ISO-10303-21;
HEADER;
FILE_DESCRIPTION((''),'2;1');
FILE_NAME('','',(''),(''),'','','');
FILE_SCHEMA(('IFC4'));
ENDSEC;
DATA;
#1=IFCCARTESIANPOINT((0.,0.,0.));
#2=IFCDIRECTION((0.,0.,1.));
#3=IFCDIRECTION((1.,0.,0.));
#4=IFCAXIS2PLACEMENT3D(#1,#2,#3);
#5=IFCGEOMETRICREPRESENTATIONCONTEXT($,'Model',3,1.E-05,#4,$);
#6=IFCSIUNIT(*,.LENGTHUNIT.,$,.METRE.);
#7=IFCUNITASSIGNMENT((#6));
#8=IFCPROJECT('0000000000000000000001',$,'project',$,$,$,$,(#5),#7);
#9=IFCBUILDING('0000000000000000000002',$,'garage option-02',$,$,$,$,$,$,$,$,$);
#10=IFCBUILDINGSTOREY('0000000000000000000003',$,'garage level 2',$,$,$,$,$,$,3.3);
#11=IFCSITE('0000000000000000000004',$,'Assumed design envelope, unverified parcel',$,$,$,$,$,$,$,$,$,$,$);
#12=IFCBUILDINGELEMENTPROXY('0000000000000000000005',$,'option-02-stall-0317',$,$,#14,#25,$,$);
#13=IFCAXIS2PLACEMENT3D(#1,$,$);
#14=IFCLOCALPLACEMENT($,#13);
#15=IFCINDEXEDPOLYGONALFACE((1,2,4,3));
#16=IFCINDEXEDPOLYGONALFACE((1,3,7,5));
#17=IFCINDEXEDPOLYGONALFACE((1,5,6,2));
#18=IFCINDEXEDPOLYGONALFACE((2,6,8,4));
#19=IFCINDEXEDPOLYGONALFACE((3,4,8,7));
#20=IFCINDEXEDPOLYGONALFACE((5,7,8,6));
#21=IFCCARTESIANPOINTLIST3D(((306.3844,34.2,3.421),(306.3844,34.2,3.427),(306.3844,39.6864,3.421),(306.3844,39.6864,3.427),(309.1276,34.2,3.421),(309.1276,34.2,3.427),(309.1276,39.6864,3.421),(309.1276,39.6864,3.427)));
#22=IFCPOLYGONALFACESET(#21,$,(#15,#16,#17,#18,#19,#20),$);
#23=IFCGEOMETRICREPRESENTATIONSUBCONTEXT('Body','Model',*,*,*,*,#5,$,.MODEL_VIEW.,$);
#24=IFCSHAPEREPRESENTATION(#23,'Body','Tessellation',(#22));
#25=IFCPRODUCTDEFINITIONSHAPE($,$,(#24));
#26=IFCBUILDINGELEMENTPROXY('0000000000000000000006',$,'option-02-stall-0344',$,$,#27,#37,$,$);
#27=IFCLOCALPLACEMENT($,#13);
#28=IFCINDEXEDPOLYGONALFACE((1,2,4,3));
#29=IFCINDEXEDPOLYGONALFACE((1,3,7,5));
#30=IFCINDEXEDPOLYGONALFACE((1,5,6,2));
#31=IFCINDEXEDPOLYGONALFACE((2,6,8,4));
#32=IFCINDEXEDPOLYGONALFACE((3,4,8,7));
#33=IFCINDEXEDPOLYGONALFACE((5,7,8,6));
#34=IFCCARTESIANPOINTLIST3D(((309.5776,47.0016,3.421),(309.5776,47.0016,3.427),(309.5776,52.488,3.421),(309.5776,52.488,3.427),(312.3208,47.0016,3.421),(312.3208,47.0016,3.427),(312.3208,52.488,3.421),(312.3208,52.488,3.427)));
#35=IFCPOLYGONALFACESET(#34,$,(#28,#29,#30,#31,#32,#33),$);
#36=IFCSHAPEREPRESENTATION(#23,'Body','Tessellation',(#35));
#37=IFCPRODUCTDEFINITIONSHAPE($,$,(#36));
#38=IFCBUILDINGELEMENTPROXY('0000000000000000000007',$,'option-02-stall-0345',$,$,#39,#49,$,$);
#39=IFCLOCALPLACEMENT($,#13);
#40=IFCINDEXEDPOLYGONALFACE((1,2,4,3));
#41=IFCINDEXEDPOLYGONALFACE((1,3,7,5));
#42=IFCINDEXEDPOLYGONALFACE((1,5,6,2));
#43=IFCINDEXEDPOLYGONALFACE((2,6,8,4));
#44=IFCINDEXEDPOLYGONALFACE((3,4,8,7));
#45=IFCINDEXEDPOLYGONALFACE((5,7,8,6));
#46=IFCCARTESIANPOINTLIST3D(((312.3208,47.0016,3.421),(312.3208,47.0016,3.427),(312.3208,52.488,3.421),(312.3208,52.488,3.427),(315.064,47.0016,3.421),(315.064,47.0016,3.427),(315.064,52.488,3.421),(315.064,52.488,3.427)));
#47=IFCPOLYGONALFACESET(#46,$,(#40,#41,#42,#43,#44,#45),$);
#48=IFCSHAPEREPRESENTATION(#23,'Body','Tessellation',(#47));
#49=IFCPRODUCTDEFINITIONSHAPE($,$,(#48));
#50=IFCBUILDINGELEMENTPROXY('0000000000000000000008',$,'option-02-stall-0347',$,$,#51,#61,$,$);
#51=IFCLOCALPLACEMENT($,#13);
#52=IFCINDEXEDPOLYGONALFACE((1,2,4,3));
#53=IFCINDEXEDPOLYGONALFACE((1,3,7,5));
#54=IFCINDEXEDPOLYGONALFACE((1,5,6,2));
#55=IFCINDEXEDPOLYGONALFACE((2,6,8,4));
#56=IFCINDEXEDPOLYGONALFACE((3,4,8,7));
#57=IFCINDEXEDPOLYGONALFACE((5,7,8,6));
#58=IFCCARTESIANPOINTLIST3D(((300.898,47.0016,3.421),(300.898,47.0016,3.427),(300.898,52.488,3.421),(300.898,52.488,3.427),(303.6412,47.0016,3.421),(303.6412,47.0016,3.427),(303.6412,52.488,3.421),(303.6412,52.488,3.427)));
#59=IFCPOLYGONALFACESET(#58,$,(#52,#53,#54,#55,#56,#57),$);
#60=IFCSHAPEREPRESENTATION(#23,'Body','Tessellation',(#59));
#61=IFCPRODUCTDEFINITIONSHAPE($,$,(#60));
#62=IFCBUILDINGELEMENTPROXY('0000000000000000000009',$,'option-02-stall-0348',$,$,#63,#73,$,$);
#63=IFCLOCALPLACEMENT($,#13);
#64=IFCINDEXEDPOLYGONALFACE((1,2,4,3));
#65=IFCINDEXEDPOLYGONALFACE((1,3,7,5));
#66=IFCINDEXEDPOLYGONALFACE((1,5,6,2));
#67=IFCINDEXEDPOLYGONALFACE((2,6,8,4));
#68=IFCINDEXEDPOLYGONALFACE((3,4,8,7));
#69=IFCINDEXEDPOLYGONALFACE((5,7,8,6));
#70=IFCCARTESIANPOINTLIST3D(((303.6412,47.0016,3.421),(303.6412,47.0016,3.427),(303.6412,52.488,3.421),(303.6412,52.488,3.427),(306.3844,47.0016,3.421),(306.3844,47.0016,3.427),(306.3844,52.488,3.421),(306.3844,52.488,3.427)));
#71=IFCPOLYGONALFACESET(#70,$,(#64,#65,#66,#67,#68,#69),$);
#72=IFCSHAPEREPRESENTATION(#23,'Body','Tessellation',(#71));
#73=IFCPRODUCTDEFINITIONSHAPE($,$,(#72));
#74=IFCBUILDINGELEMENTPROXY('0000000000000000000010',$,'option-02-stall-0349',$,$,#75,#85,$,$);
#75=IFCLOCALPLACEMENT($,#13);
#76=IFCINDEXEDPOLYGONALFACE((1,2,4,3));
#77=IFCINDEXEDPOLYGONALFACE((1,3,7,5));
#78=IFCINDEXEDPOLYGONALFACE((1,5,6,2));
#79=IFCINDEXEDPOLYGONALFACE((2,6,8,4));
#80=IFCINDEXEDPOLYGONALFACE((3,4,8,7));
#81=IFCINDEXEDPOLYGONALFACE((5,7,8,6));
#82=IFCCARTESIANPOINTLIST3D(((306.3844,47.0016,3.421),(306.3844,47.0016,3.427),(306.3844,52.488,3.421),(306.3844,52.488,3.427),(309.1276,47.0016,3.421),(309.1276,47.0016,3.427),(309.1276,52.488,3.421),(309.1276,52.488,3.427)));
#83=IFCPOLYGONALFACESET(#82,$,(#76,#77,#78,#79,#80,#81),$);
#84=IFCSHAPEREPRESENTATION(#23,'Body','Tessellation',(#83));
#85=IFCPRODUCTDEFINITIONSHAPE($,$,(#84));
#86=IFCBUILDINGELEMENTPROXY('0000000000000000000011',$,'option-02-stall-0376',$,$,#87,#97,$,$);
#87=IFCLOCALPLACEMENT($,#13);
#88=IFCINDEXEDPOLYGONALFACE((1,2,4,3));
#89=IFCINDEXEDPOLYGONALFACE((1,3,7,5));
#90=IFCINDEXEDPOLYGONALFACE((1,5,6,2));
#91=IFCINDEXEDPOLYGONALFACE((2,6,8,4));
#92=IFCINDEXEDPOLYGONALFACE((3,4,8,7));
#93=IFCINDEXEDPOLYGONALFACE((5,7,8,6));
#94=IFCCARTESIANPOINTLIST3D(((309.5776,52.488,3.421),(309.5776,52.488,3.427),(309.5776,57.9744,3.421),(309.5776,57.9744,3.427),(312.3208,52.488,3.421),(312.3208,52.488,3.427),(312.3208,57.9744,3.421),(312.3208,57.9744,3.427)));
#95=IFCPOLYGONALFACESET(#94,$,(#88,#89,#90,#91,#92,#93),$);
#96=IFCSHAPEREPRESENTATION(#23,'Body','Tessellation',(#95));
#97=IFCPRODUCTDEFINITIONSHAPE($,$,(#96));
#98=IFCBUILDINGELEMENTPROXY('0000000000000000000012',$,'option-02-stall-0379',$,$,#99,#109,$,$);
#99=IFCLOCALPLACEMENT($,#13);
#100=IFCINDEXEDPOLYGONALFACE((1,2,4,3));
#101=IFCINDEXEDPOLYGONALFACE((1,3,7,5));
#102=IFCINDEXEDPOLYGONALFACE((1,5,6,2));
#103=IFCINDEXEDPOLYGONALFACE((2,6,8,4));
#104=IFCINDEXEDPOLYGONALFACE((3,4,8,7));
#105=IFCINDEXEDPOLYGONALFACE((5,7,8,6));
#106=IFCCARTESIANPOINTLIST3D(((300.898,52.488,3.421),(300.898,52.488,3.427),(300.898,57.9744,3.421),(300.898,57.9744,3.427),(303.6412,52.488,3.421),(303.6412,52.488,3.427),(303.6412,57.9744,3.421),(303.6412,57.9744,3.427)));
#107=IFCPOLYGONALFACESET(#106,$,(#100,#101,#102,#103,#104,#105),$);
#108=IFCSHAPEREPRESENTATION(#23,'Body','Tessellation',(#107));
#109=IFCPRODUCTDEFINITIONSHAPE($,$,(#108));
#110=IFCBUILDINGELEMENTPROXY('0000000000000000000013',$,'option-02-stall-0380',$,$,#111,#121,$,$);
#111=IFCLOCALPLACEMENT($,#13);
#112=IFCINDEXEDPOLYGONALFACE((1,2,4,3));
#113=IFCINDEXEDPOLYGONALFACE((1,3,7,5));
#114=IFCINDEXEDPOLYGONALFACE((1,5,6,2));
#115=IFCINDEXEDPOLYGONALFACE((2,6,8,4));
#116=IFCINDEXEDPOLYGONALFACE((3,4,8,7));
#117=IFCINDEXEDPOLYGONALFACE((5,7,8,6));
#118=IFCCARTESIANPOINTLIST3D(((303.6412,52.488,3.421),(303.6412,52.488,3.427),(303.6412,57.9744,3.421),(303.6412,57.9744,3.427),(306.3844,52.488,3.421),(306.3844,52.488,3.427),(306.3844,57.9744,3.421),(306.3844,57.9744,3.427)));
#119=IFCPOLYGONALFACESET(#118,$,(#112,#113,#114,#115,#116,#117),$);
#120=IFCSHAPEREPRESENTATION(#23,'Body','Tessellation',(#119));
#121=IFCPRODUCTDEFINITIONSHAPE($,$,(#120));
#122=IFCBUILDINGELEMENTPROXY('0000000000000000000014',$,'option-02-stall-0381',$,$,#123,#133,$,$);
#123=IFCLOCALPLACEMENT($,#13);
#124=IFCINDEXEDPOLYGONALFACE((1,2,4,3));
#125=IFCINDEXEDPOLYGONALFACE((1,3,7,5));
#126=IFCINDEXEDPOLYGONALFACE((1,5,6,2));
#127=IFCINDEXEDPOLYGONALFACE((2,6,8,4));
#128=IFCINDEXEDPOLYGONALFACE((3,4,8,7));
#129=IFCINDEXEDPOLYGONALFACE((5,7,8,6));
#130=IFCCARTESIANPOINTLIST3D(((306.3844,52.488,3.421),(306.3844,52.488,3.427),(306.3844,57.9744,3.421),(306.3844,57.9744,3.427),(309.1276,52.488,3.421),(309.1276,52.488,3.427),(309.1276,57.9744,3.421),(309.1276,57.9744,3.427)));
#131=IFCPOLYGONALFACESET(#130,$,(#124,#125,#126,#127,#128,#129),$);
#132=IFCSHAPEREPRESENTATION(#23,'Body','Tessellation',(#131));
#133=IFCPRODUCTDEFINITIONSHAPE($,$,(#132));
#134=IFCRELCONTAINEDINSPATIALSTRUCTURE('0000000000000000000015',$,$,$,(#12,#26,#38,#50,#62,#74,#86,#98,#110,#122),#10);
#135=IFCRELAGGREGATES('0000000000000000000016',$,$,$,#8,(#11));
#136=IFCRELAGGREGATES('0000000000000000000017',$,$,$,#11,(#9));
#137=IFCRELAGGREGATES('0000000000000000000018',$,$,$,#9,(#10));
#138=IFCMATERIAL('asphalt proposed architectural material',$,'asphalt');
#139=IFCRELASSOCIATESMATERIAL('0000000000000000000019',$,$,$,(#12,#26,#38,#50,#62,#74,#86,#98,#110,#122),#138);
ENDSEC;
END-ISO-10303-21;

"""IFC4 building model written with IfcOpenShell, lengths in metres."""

from ifc_helpers import new_model, si_unit, frame, origin_with_axes, place, context, subcontext, project, spatial, rectangle, extrude, material, element, save


model = new_model("IFC4")

# Units and contexts
model_context = context("Model", 3, precision=1e-05, world=origin_with_axes())
body_context = subcontext(model_context, "Body", "Model", "MODEL_VIEW")
ifc_project = project(units=[si_unit("LENGTHUNIT", "METRE")], contexts=[model_context])

# Site, building, storey
site = spatial("IfcSite", under=ifc_project, Name="Assumed design envelope, unverified parcel")
building = spatial("IfcBuilding", under=site, Name="garage option-02")
storey = spatial("IfcBuildingStorey", under=building, Name="garage level 2", Elevation=3.3)

# Building element proxies
ifc_material_1 = material(Name="asphalt proposed architectural material", Category="asphalt")
for number, where, z_axis, x_axis, name in (
    (1, (307.756, 36.9432, 3.421), (0.0, 0.0, 1.0), (1.0, 0.0, 0.0), "option-02-stall-0317"),
    (2, (310.9492, 49.7448, 3.421), (0.0, 0.0, 1.0), (1.0, 0.0, 0.0), "option-02-stall-0344"),
    (3, (313.6924, 49.7448, 3.421), (0.0, 0.0, 1.0), (1.0, 0.0, 0.0), "option-02-stall-0345"),
    (4, (302.2696, 49.7448, 3.421), (0.0, 0.0, 1.0), (1.0, 0.0, 0.0), "option-02-stall-0347"),
    (5, (305.0128, 49.7448, 3.421), (0.0, 0.0, 1.0), (1.0, 0.0, 0.0), "option-02-stall-0348"),
    (6, (307.756, 49.7448, 3.421), (0.0, 0.0, 1.0), (1.0, 0.0, 0.0), "option-02-stall-0349"),
):
    element("IfcBuildingElementProxy", number, at=place(None, frame(where, z_axis=z_axis, x_axis=x_axis)), inside=storey, material=ifc_material_1, Name=name, context=body_context, shape_type="SweptSolid", body=[
        extrude(rectangle(XDim=2.7432, YDim=5.4864), origin_with_axes(), (0.0, 0.0, 1.0), 0.006),
    ])
for number, where, z_axis, x_axis, name in (
    (7, (310.9492, 55.2312, 3.421), (0.0, 0.0, 1.0), (1.0, 0.0, 0.0), "option-02-stall-0376"),
    (8, (302.2696, 55.2312, 3.421), (0.0, 0.0, 1.0), (1.0, 0.0, 0.0), "option-02-stall-0379"),
    (9, (305.0128, 55.2312, 3.421), (0.0, 0.0, 1.0), (1.0, 0.0, 0.0), "option-02-stall-0380"),
    (10, (307.756, 55.2312, 3.421), (0.0, 0.0, 1.0), (1.0, 0.0, 0.0), "option-02-stall-0381"),
):
    element("IfcBuildingElementProxy", number, at=place(None, frame(where, z_axis=z_axis, x_axis=x_axis)), inside=storey, material=ifc_material_1, Name=name, context=body_context, shape_type="SweptSolid", body=[
        extrude(rectangle(XDim=2.7432, YDim=5.4864), origin_with_axes(), (0.0, 0.0, 1.0), 0.006),
    ])

save(model, "model.ifc")
